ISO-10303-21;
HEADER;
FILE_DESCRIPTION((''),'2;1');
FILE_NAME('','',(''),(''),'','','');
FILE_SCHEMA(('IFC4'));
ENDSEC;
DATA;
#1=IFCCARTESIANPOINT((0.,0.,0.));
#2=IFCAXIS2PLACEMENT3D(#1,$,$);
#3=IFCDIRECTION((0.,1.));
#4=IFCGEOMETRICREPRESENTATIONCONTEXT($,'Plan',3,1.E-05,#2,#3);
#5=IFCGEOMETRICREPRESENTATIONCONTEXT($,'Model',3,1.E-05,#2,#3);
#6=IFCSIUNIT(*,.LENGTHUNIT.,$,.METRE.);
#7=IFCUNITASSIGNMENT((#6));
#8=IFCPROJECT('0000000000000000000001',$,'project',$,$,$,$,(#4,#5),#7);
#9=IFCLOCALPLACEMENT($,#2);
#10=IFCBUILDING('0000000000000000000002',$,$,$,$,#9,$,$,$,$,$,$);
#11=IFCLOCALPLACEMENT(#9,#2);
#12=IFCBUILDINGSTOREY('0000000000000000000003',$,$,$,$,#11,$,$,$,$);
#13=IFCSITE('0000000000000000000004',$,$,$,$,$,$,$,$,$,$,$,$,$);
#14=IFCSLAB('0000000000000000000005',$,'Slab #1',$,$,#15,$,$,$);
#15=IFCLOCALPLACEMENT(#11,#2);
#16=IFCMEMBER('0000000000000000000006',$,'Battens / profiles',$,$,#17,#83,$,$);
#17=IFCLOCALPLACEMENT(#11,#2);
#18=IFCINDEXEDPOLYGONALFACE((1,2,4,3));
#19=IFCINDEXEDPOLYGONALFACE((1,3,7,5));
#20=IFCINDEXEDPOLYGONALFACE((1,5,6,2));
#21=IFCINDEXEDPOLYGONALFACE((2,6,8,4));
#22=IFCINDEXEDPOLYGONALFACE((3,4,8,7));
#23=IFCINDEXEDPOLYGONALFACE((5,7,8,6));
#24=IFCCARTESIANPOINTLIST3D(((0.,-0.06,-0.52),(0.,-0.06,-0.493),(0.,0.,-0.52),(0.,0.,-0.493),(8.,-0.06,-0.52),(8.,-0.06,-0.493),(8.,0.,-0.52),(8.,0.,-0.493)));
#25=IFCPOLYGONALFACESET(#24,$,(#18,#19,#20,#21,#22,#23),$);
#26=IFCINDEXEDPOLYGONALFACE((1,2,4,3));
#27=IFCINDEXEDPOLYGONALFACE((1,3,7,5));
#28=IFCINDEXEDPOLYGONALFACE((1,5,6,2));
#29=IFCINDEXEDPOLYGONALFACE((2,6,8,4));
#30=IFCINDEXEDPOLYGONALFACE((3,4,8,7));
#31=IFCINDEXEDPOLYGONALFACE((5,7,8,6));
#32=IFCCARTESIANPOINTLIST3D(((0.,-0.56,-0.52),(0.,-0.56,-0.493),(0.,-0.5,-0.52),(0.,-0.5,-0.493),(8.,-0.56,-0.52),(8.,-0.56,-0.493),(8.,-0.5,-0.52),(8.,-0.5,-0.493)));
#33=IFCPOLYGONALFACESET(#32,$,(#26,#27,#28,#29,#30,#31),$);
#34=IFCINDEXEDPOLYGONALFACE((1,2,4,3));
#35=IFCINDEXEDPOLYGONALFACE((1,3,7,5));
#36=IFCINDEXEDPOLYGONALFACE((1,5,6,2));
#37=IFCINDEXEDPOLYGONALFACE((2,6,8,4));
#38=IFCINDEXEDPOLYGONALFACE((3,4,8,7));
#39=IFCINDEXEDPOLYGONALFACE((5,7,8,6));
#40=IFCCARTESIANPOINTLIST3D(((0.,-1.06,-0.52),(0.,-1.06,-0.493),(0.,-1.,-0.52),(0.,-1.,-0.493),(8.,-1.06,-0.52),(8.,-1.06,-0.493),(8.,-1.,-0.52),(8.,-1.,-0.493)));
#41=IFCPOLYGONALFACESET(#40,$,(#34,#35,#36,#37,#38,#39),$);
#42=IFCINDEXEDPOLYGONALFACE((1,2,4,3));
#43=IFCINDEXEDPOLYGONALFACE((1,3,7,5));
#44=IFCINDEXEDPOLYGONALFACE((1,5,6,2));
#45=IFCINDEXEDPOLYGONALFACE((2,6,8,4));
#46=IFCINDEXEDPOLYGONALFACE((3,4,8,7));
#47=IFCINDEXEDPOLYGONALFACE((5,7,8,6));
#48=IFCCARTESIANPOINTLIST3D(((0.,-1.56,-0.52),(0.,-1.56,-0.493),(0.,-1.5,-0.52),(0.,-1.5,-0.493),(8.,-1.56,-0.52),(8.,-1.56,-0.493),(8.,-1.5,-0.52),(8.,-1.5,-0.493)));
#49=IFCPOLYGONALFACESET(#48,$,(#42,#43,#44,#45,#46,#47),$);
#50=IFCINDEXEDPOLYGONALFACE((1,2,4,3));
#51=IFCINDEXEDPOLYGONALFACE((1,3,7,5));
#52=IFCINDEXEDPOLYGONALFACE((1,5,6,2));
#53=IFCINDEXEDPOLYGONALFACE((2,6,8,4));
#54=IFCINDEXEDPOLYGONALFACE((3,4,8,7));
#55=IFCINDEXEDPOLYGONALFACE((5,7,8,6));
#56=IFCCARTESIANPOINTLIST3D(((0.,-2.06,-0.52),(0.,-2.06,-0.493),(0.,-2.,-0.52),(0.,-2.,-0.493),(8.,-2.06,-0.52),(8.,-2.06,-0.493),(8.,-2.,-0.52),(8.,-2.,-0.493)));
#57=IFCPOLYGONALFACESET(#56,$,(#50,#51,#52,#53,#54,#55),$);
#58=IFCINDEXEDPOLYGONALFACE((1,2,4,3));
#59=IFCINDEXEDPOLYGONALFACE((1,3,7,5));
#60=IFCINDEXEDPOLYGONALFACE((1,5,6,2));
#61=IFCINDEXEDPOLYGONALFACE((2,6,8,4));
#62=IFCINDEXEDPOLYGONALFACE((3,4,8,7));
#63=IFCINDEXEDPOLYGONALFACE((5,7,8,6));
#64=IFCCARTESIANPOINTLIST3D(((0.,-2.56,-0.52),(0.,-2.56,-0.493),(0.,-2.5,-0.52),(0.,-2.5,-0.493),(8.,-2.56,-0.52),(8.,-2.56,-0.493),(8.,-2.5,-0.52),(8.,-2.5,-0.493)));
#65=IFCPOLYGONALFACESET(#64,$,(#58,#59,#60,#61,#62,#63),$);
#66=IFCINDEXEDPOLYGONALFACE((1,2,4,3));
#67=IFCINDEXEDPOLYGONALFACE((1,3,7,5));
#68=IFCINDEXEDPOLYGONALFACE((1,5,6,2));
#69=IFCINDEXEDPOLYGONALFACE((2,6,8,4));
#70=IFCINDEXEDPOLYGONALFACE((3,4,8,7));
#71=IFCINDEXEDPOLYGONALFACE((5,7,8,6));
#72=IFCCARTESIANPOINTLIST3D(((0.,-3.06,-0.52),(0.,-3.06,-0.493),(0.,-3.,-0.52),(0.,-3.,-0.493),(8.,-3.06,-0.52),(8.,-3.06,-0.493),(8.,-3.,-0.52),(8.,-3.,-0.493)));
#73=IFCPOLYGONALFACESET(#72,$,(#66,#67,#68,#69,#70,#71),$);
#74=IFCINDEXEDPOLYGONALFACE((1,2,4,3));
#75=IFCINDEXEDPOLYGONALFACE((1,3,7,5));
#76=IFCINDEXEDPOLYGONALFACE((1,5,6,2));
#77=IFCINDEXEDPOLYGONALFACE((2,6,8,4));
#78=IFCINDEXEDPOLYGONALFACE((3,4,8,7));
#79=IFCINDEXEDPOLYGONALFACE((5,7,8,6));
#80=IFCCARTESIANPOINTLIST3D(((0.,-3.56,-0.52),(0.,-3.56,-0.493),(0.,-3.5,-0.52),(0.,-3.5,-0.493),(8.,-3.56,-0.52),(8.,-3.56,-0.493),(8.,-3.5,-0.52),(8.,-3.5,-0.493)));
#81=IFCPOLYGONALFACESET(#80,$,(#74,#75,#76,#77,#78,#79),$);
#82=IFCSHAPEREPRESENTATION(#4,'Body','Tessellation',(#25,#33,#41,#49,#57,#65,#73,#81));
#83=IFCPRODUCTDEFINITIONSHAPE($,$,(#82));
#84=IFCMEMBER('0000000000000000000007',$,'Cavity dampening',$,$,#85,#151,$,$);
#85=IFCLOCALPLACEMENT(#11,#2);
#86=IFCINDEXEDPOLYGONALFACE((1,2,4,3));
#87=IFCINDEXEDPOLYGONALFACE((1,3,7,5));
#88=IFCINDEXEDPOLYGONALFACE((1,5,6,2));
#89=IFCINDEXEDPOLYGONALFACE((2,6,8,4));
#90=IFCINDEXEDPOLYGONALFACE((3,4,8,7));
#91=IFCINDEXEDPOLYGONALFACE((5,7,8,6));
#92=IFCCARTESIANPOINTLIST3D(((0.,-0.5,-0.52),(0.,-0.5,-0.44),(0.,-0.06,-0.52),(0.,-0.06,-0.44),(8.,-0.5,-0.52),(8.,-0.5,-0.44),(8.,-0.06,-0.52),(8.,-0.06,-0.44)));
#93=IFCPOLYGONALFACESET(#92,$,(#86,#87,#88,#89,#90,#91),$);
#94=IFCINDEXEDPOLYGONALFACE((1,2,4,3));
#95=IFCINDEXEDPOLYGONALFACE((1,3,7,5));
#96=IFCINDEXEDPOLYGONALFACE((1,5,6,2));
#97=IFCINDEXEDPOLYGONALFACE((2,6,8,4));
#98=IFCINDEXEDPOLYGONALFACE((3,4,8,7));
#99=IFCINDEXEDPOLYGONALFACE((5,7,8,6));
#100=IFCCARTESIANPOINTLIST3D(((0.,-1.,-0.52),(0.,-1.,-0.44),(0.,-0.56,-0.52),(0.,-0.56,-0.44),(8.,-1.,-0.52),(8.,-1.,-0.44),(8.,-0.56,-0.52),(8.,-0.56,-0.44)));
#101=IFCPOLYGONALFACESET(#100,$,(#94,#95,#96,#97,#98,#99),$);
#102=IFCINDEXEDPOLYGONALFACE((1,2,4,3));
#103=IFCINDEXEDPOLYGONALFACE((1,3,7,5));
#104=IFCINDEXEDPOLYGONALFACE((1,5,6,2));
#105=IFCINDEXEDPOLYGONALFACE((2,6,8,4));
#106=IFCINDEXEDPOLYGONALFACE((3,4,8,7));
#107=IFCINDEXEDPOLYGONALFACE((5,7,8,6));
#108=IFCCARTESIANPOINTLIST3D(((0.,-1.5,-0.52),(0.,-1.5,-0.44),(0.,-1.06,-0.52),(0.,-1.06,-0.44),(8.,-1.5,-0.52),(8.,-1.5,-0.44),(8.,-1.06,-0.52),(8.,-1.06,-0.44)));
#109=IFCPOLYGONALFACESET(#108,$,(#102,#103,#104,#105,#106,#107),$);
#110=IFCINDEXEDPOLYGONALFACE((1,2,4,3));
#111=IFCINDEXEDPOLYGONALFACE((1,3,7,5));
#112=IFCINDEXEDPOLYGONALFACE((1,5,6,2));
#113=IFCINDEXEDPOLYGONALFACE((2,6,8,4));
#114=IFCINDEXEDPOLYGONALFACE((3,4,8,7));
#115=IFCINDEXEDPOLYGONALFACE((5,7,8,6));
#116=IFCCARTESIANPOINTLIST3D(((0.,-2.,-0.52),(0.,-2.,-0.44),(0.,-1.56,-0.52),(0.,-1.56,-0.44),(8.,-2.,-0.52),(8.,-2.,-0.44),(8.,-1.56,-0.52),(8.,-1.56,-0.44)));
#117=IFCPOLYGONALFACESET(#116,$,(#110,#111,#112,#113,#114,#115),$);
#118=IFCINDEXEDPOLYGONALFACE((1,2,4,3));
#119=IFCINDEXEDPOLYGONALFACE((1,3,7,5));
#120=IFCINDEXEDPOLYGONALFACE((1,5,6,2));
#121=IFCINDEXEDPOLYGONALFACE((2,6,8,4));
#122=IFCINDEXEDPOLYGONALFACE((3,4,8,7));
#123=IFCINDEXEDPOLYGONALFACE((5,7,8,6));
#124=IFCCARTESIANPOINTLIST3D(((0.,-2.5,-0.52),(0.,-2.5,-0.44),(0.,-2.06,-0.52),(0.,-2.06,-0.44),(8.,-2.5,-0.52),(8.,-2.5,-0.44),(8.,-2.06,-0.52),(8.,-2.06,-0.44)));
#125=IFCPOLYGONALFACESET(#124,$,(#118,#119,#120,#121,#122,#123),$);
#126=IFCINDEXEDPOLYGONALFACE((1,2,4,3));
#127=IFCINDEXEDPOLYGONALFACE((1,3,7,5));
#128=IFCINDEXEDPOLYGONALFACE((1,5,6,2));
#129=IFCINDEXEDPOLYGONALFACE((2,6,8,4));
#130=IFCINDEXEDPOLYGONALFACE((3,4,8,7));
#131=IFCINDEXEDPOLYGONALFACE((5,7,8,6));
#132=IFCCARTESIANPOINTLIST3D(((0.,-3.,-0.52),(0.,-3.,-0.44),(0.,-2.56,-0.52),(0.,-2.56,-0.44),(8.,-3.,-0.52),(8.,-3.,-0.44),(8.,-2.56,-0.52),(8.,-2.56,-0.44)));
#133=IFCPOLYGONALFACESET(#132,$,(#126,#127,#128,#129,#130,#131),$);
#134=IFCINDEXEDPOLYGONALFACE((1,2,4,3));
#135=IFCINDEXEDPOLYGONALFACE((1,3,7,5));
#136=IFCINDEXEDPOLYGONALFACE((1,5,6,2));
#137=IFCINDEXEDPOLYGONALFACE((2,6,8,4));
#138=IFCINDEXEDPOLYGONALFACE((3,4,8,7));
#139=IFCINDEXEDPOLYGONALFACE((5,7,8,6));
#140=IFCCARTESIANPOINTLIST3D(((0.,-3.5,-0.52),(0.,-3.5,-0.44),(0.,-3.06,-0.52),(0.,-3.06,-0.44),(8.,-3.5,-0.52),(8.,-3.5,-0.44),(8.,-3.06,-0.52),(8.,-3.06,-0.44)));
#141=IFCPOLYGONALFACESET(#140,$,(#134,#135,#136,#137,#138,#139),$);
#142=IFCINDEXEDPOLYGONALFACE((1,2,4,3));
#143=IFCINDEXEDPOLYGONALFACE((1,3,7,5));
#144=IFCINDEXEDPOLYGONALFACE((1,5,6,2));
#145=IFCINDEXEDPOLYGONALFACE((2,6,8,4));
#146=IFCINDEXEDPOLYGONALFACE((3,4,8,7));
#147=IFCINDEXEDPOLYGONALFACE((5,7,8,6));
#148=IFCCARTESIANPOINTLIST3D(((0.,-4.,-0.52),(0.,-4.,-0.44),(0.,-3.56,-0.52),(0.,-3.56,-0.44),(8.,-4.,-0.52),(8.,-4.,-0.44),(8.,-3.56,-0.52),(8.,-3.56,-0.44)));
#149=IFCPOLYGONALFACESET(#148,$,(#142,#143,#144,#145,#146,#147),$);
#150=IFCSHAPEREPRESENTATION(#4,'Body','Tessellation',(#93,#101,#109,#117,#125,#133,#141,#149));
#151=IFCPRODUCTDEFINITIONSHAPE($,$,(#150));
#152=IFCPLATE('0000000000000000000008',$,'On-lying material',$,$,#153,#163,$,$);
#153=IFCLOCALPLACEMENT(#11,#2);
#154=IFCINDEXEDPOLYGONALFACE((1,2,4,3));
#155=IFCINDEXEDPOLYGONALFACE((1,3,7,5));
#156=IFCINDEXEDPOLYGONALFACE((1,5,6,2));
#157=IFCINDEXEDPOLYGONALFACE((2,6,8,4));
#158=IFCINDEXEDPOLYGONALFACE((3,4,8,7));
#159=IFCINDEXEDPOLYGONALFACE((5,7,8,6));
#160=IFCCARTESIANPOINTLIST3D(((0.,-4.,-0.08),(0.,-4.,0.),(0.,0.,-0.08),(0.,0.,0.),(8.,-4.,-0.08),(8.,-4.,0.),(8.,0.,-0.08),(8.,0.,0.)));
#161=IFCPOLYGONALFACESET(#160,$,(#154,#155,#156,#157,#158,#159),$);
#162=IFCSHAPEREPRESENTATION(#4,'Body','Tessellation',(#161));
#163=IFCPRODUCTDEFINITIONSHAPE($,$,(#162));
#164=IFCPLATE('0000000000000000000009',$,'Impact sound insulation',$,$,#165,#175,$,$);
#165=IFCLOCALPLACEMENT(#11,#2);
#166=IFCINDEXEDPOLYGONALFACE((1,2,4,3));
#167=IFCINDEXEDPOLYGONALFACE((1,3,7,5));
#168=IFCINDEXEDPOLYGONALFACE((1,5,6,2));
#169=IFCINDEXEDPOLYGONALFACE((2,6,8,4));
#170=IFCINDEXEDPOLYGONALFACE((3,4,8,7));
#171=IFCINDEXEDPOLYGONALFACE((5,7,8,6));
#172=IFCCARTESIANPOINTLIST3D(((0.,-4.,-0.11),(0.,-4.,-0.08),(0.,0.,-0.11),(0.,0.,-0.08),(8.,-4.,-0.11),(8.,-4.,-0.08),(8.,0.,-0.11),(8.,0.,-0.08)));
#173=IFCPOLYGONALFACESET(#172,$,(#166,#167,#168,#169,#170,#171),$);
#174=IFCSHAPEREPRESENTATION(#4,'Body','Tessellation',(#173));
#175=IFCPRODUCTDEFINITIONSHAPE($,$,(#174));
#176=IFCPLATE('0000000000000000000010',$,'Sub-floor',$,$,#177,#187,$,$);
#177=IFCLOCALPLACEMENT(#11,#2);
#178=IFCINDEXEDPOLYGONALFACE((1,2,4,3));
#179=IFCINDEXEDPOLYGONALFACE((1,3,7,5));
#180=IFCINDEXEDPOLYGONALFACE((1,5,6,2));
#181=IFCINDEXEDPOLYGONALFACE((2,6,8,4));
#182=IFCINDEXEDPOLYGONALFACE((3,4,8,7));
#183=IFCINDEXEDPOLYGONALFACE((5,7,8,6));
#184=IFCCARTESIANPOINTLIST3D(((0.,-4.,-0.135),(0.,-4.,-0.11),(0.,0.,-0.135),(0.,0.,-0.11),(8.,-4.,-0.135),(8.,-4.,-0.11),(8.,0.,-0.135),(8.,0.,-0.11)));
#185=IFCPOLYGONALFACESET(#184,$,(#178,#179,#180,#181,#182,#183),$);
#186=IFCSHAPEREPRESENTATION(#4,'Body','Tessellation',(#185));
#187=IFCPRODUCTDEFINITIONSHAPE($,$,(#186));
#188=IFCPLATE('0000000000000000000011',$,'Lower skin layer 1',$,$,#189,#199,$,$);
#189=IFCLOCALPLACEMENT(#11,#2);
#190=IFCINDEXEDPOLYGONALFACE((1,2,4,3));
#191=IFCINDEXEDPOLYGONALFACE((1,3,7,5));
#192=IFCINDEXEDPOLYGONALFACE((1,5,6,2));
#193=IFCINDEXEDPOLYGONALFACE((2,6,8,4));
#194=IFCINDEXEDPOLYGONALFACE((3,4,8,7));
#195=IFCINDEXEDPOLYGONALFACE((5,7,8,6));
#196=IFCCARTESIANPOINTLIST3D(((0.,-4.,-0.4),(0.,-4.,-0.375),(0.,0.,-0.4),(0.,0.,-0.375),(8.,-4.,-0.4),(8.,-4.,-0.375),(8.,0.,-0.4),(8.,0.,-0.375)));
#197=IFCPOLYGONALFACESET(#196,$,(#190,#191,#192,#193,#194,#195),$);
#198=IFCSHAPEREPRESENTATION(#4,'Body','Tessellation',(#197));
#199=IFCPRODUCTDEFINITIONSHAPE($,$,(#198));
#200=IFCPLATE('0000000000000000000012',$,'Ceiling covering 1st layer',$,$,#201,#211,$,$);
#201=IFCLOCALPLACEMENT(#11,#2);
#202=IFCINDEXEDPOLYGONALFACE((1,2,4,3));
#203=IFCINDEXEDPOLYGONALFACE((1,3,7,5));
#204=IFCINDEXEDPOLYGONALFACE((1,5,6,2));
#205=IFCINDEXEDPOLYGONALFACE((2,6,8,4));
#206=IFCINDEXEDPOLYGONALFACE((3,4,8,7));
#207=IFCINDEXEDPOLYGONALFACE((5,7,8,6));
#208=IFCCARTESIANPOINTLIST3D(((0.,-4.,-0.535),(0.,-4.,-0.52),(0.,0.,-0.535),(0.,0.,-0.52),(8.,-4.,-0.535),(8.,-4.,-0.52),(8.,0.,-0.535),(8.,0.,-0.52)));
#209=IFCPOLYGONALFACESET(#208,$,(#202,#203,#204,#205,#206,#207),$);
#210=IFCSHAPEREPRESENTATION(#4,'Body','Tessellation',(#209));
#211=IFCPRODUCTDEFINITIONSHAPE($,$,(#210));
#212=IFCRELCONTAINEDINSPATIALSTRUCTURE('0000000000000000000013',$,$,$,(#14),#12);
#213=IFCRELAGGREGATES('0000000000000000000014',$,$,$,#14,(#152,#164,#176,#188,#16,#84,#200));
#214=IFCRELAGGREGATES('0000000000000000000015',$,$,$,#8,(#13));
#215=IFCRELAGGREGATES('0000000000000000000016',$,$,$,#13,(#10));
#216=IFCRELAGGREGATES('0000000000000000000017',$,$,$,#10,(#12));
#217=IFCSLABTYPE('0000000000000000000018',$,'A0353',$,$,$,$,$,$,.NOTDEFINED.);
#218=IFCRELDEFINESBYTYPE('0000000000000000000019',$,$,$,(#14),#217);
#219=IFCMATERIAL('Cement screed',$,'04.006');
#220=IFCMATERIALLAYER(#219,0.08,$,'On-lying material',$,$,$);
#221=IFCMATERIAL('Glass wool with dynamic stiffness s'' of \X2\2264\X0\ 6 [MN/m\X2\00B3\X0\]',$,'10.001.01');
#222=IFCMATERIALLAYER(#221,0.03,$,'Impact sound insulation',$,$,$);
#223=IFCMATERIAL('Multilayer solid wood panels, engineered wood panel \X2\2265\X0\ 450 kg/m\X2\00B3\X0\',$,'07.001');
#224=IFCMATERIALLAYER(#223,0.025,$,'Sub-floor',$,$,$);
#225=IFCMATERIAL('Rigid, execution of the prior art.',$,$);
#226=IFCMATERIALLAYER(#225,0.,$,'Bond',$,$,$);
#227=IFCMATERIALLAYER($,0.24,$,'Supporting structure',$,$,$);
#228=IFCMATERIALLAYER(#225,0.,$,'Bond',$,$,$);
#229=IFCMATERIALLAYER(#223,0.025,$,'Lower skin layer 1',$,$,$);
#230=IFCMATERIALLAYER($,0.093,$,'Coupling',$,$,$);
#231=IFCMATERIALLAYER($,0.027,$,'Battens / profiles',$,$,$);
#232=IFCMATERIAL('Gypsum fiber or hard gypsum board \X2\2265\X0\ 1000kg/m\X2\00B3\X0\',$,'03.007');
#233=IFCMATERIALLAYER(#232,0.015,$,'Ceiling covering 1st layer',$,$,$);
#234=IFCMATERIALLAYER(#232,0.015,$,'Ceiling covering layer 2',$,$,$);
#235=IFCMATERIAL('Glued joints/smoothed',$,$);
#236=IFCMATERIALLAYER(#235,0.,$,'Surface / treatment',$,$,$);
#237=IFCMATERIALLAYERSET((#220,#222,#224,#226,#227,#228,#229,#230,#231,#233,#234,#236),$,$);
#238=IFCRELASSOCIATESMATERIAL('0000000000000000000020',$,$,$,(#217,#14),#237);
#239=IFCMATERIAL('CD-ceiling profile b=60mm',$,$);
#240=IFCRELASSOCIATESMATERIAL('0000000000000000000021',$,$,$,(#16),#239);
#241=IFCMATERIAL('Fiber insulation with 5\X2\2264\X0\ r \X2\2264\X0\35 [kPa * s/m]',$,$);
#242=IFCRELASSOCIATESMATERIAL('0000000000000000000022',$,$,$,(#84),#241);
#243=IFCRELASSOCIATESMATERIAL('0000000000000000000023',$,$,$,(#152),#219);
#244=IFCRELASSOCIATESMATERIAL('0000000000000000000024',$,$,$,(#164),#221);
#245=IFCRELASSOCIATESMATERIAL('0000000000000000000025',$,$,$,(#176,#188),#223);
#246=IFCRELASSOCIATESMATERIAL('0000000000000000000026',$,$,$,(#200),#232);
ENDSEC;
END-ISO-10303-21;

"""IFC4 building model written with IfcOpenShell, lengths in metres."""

from ifc_helpers import new_model, si_unit, direction, frame, frame_2d, origin, origin_with_axes, place, context, project, spatial, rectangle, extrude, material, layer, layer_set, type_object, element, aggregate, save


model = new_model("IFC4")

# Units and contexts
plan_context = context("Plan", 3, precision=1e-05, world=origin(), true_north=direction((0.0, 1.0)))
model_context = context("Model", 3, precision=1e-05, world=origin(), true_north=direction((0.0, 1.0)))
ifc_project = project(units=[si_unit("LENGTHUNIT", "METRE")], contexts=[plan_context, model_context])

# Site, building, storey
site = spatial("IfcSite", under=ifc_project)
building_placement = place(None, origin())
building = spatial("IfcBuilding", under=site, at=building_placement)
storey_placement = place(building_placement, origin())
storey = spatial("IfcBuildingStorey", under=building, at=storey_placement)

# Slab, members, plates
ifc_material_1 = material(Name="Cement screed", Category="04.006")
ifc_layer_1 = layer(ifc_material_1, 0.08, Name="On-lying material")
ifc_material_2 = material(Name="Glass wool with dynamic stiffness s' of ≤ 6 [MN/m³]", Category="10.001.01")
ifc_layer_2 = layer(ifc_material_2, 0.03, Name="Impact sound insulation")
ifc_material_3 = material(Name="Multilayer solid wood panels, engineered wood panel ≥ 450 kg/m³", Category="07.001")
ifc_layer_3 = layer(ifc_material_3, 0.025, Name="Sub-floor")
ifc_material_4 = material(Name="Rigid, execution of the prior art.")
ifc_layer_4 = layer(ifc_material_4, 0.0, Name="Bond")
ifc_layer_5 = layer(None, 0.24, Name="Supporting structure")
ifc_layer_6 = layer(ifc_material_4, 0.0, Name="Bond")
ifc_layer_7 = layer(ifc_material_3, 0.025, Name="Lower skin layer 1")
ifc_layer_8 = layer(None, 0.093, Name="Coupling")
ifc_layer_9 = layer(None, 0.027, Name="Battens / profiles")
ifc_material_5 = material(Name="Gypsum fiber or hard gypsum board ≥ 1000kg/m³", Category="03.007")
ifc_layer_10 = layer(ifc_material_5, 0.015, Name="Ceiling covering 1st layer")
ifc_layer_11 = layer(ifc_material_5, 0.015, Name="Ceiling covering layer 2")
ifc_material_6 = material(Name="Glued joints/smoothed")
ifc_layer_12 = layer(ifc_material_6, 0.0, Name="Surface / treatment")
ifc_layer_set = layer_set([ifc_layer_1, ifc_layer_2, ifc_layer_3, ifc_layer_4, ifc_layer_5, ifc_layer_6, ifc_layer_7, ifc_layer_8, ifc_layer_9, ifc_layer_10, ifc_layer_11, ifc_layer_12])
slab_type = type_object("IfcSlabType", Name="A0353", PredefinedType="NOTDEFINED", material=ifc_layer_set)
slab_placement = place(None, frame((0.0, 0.0, 0.0), z_axis=(0.0, 0.0, -1.0), x_axis=(1.0, 0.0, 0.0)))
slab = element("IfcSlab", 1, at=slab_placement, inside=storey, type_object=slab_type, material=ifc_layer_set, Name="Slab #1")
ifc_material_7 = material(Name="Fiber insulation with 5≤ r ≤35 [kPa * s/m]")
ifc_material_8 = material(Name="CD-ceiling profile b=60mm")
member_1_placement = place(slab_placement, origin())
member_1 = element("IfcMember", 2, at=member_1_placement, material=ifc_material_8, Name="Battens / profiles", context=plan_context, shape_type="SweptSolid", body=[
    extrude(rectangle(XDim=0.06, YDim=0.027, at=frame_2d((0.03, 0.0135), x_axis=(1.0, 0.0))), frame((0.0, 0.0, 0.493), z_axis=(1.0, 0.0, 0.0), x_axis=(0.0, 1.0, 0.0)), (0.0, 0.0, 1.0), 8.0),
    extrude(rectangle(XDim=0.06, YDim=0.027, at=frame_2d((0.03, 0.0135), x_axis=(1.0, 0.0))), frame((0.0, 0.5, 0.493), z_axis=(1.0, 0.0, 0.0), x_axis=(0.0, 1.0, 0.0)), (0.0, 0.0, 1.0), 8.0),
    extrude(rectangle(XDim=0.06, YDim=0.027, at=frame_2d((0.03, 0.0135), x_axis=(1.0, 0.0))), frame((0.0, 1.0, 0.493), z_axis=(1.0, 0.0, 0.0), x_axis=(0.0, 1.0, 0.0)), (0.0, 0.0, 1.0), 8.0),
    extrude(rectangle(XDim=0.06, YDim=0.027, at=frame_2d((0.03, 0.0135), x_axis=(1.0, 0.0))), frame((0.0, 1.5, 0.493), z_axis=(1.0, 0.0, 0.0), x_axis=(0.0, 1.0, 0.0)), (0.0, 0.0, 1.0), 8.0),
    extrude(rectangle(XDim=0.06, YDim=0.027, at=frame_2d((0.03, 0.0135), x_axis=(1.0, 0.0))), frame((0.0, 2.0, 0.493), z_axis=(1.0, 0.0, 0.0), x_axis=(0.0, 1.0, 0.0)), (0.0, 0.0, 1.0), 8.0),
    extrude(rectangle(XDim=0.06, YDim=0.027, at=frame_2d((0.03, 0.0135), x_axis=(1.0, 0.0))), frame((0.0, 2.5, 0.493), z_axis=(1.0, 0.0, 0.0), x_axis=(0.0, 1.0, 0.0)), (0.0, 0.0, 1.0), 8.0),
    extrude(rectangle(XDim=0.06, YDim=0.027, at=frame_2d((0.03, 0.0135), x_axis=(1.0, 0.0))), frame((0.0, 3.0, 0.493), z_axis=(1.0, 0.0, 0.0), x_axis=(0.0, 1.0, 0.0)), (0.0, 0.0, 1.0), 8.0),
    extrude(rectangle(XDim=0.06, YDim=0.027, at=frame_2d((0.03, 0.0135), x_axis=(1.0, 0.0))), frame((0.0, 3.5, 0.493), z_axis=(1.0, 0.0, 0.0), x_axis=(0.0, 1.0, 0.0)), (0.0, 0.0, 1.0), 8.0),
])
member_2_placement = place(slab_placement, origin())
member_2 = element("IfcMember", 3, at=member_2_placement, material=ifc_material_7, Name="Cavity dampening", context=plan_context, shape_type="SweptSolid", body=[
    extrude(rectangle(XDim=0.44, YDim=0.08, at=frame_2d((0.22, 0.04), x_axis=(1.0, 0.0))), frame((0.0, 0.06, 0.44), z_axis=(1.0, 0.0, 0.0), x_axis=(0.0, 1.0, 0.0)), (0.0, 0.0, 1.0), 8.0),
    extrude(rectangle(XDim=0.44, YDim=0.08, at=frame_2d((0.22, 0.04), x_axis=(1.0, 0.0))), frame((0.0, 0.56, 0.44), z_axis=(1.0, 0.0, 0.0), x_axis=(0.0, 1.0, 0.0)), (0.0, 0.0, 1.0), 8.0),
    extrude(rectangle(XDim=0.44, YDim=0.08, at=frame_2d((0.22, 0.04), x_axis=(1.0, 0.0))), frame((0.0, 1.06, 0.44), z_axis=(1.0, 0.0, 0.0), x_axis=(0.0, 1.0, 0.0)), (0.0, 0.0, 1.0), 8.0),
    extrude(rectangle(XDim=0.44, YDim=0.08, at=frame_2d((0.22, 0.04), x_axis=(1.0, 0.0))), frame((0.0, 1.56, 0.44), z_axis=(1.0, 0.0, 0.0), x_axis=(0.0, 1.0, 0.0)), (0.0, 0.0, 1.0), 8.0),
    extrude(rectangle(XDim=0.44, YDim=0.08, at=frame_2d((0.22, 0.04), x_axis=(1.0, 0.0))), frame((0.0, 2.06, 0.44), z_axis=(1.0, 0.0, 0.0), x_axis=(0.0, 1.0, 0.0)), (0.0, 0.0, 1.0), 8.0),
    extrude(rectangle(XDim=0.44, YDim=0.08, at=frame_2d((0.22, 0.04), x_axis=(1.0, 0.0))), frame((0.0, 2.56, 0.44), z_axis=(1.0, 0.0, 0.0), x_axis=(0.0, 1.0, 0.0)), (0.0, 0.0, 1.0), 8.0),
    extrude(rectangle(XDim=0.44, YDim=0.08, at=frame_2d((0.22, 0.04), x_axis=(1.0, 0.0))), frame((0.0, 3.06, 0.44), z_axis=(1.0, 0.0, 0.0), x_axis=(0.0, 1.0, 0.0)), (0.0, 0.0, 1.0), 8.0),
    extrude(rectangle(XDim=0.44, YDim=0.08, at=frame_2d((0.22, 0.04), x_axis=(1.0, 0.0))), frame((0.0, 3.56, 0.44), z_axis=(1.0, 0.0, 0.0), x_axis=(0.0, 1.0, 0.0)), (0.0, 0.0, 1.0), 8.0),
])
plate_1_placement = place(slab_placement, origin())
plate_1 = element("IfcPlate", 4, at=plate_1_placement, material=ifc_material_1, Name="On-lying material", context=plan_context, shape_type="SweptSolid", body=[
    extrude(rectangle(XDim=8.0, YDim=4.0, at=frame_2d((4.0, 2.0), x_axis=(1.0, 0.0))), origin_with_axes(), (0.0, 0.0, 1.0), 0.08),
])
plate_2_placement = place(slab_placement, origin())
plate_2 = element("IfcPlate", 5, at=plate_2_placement, material=ifc_material_2, Name="Impact sound insulation", context=plan_context, shape_type="SweptSolid", body=[
    extrude(rectangle(XDim=8.0, YDim=4.0, at=frame_2d((4.0, 2.0), x_axis=(1.0, 0.0))), frame((0.0, 0.0, 0.08), z_axis=(0.0, 0.0, 1.0), x_axis=(1.0, 0.0, 0.0)), (0.0, 0.0, 1.0), 0.03),
])
plate_3_placement = place(slab_placement, origin())
plate_3 = element("IfcPlate", 6, at=plate_3_placement, material=ifc_material_3, Name="Sub-floor", context=plan_context, shape_type="SweptSolid", body=[
    extrude(rectangle(XDim=8.0, YDim=4.0, at=frame_2d((4.0, 2.0), x_axis=(1.0, 0.0))), frame((0.0, 0.0, 0.11), z_axis=(0.0, 0.0, 1.0), x_axis=(1.0, 0.0, 0.0)), (0.0, 0.0, 1.0), 0.025),
])
plate_4_placement = place(slab_placement, origin())
plate_4 = element("IfcPlate", 7, at=plate_4_placement, material=ifc_material_3, Name="Lower skin layer 1", context=plan_context, shape_type="SweptSolid", body=[
    extrude(rectangle(XDim=8.0, YDim=4.0, at=frame_2d((4.0, 2.0), x_axis=(1.0, 0.0))), frame((0.0, 0.0, 0.375), z_axis=(0.0, 0.0, 1.0), x_axis=(1.0, 0.0, 0.0)), (0.0, 0.0, 1.0), 0.025),
])
plate_5_placement = place(slab_placement, origin())
plate_5 = element("IfcPlate", 8, at=plate_5_placement, material=ifc_material_5, Name="Ceiling covering 1st layer", context=plan_context, shape_type="SweptSolid", body=[
    extrude(rectangle(XDim=8.0, YDim=4.0, at=frame_2d((4.0, 2.0), x_axis=(1.0, 0.0))), frame((0.0, 0.0, 0.52), z_axis=(0.0, 0.0, 1.0), x_axis=(1.0, 0.0, 0.0)), (0.0, 0.0, 1.0), 0.015),
])
aggregate(slab, [plate_1, plate_2, plate_3, plate_4, member_1, member_2, plate_5])

save(model, "model.ifc")
